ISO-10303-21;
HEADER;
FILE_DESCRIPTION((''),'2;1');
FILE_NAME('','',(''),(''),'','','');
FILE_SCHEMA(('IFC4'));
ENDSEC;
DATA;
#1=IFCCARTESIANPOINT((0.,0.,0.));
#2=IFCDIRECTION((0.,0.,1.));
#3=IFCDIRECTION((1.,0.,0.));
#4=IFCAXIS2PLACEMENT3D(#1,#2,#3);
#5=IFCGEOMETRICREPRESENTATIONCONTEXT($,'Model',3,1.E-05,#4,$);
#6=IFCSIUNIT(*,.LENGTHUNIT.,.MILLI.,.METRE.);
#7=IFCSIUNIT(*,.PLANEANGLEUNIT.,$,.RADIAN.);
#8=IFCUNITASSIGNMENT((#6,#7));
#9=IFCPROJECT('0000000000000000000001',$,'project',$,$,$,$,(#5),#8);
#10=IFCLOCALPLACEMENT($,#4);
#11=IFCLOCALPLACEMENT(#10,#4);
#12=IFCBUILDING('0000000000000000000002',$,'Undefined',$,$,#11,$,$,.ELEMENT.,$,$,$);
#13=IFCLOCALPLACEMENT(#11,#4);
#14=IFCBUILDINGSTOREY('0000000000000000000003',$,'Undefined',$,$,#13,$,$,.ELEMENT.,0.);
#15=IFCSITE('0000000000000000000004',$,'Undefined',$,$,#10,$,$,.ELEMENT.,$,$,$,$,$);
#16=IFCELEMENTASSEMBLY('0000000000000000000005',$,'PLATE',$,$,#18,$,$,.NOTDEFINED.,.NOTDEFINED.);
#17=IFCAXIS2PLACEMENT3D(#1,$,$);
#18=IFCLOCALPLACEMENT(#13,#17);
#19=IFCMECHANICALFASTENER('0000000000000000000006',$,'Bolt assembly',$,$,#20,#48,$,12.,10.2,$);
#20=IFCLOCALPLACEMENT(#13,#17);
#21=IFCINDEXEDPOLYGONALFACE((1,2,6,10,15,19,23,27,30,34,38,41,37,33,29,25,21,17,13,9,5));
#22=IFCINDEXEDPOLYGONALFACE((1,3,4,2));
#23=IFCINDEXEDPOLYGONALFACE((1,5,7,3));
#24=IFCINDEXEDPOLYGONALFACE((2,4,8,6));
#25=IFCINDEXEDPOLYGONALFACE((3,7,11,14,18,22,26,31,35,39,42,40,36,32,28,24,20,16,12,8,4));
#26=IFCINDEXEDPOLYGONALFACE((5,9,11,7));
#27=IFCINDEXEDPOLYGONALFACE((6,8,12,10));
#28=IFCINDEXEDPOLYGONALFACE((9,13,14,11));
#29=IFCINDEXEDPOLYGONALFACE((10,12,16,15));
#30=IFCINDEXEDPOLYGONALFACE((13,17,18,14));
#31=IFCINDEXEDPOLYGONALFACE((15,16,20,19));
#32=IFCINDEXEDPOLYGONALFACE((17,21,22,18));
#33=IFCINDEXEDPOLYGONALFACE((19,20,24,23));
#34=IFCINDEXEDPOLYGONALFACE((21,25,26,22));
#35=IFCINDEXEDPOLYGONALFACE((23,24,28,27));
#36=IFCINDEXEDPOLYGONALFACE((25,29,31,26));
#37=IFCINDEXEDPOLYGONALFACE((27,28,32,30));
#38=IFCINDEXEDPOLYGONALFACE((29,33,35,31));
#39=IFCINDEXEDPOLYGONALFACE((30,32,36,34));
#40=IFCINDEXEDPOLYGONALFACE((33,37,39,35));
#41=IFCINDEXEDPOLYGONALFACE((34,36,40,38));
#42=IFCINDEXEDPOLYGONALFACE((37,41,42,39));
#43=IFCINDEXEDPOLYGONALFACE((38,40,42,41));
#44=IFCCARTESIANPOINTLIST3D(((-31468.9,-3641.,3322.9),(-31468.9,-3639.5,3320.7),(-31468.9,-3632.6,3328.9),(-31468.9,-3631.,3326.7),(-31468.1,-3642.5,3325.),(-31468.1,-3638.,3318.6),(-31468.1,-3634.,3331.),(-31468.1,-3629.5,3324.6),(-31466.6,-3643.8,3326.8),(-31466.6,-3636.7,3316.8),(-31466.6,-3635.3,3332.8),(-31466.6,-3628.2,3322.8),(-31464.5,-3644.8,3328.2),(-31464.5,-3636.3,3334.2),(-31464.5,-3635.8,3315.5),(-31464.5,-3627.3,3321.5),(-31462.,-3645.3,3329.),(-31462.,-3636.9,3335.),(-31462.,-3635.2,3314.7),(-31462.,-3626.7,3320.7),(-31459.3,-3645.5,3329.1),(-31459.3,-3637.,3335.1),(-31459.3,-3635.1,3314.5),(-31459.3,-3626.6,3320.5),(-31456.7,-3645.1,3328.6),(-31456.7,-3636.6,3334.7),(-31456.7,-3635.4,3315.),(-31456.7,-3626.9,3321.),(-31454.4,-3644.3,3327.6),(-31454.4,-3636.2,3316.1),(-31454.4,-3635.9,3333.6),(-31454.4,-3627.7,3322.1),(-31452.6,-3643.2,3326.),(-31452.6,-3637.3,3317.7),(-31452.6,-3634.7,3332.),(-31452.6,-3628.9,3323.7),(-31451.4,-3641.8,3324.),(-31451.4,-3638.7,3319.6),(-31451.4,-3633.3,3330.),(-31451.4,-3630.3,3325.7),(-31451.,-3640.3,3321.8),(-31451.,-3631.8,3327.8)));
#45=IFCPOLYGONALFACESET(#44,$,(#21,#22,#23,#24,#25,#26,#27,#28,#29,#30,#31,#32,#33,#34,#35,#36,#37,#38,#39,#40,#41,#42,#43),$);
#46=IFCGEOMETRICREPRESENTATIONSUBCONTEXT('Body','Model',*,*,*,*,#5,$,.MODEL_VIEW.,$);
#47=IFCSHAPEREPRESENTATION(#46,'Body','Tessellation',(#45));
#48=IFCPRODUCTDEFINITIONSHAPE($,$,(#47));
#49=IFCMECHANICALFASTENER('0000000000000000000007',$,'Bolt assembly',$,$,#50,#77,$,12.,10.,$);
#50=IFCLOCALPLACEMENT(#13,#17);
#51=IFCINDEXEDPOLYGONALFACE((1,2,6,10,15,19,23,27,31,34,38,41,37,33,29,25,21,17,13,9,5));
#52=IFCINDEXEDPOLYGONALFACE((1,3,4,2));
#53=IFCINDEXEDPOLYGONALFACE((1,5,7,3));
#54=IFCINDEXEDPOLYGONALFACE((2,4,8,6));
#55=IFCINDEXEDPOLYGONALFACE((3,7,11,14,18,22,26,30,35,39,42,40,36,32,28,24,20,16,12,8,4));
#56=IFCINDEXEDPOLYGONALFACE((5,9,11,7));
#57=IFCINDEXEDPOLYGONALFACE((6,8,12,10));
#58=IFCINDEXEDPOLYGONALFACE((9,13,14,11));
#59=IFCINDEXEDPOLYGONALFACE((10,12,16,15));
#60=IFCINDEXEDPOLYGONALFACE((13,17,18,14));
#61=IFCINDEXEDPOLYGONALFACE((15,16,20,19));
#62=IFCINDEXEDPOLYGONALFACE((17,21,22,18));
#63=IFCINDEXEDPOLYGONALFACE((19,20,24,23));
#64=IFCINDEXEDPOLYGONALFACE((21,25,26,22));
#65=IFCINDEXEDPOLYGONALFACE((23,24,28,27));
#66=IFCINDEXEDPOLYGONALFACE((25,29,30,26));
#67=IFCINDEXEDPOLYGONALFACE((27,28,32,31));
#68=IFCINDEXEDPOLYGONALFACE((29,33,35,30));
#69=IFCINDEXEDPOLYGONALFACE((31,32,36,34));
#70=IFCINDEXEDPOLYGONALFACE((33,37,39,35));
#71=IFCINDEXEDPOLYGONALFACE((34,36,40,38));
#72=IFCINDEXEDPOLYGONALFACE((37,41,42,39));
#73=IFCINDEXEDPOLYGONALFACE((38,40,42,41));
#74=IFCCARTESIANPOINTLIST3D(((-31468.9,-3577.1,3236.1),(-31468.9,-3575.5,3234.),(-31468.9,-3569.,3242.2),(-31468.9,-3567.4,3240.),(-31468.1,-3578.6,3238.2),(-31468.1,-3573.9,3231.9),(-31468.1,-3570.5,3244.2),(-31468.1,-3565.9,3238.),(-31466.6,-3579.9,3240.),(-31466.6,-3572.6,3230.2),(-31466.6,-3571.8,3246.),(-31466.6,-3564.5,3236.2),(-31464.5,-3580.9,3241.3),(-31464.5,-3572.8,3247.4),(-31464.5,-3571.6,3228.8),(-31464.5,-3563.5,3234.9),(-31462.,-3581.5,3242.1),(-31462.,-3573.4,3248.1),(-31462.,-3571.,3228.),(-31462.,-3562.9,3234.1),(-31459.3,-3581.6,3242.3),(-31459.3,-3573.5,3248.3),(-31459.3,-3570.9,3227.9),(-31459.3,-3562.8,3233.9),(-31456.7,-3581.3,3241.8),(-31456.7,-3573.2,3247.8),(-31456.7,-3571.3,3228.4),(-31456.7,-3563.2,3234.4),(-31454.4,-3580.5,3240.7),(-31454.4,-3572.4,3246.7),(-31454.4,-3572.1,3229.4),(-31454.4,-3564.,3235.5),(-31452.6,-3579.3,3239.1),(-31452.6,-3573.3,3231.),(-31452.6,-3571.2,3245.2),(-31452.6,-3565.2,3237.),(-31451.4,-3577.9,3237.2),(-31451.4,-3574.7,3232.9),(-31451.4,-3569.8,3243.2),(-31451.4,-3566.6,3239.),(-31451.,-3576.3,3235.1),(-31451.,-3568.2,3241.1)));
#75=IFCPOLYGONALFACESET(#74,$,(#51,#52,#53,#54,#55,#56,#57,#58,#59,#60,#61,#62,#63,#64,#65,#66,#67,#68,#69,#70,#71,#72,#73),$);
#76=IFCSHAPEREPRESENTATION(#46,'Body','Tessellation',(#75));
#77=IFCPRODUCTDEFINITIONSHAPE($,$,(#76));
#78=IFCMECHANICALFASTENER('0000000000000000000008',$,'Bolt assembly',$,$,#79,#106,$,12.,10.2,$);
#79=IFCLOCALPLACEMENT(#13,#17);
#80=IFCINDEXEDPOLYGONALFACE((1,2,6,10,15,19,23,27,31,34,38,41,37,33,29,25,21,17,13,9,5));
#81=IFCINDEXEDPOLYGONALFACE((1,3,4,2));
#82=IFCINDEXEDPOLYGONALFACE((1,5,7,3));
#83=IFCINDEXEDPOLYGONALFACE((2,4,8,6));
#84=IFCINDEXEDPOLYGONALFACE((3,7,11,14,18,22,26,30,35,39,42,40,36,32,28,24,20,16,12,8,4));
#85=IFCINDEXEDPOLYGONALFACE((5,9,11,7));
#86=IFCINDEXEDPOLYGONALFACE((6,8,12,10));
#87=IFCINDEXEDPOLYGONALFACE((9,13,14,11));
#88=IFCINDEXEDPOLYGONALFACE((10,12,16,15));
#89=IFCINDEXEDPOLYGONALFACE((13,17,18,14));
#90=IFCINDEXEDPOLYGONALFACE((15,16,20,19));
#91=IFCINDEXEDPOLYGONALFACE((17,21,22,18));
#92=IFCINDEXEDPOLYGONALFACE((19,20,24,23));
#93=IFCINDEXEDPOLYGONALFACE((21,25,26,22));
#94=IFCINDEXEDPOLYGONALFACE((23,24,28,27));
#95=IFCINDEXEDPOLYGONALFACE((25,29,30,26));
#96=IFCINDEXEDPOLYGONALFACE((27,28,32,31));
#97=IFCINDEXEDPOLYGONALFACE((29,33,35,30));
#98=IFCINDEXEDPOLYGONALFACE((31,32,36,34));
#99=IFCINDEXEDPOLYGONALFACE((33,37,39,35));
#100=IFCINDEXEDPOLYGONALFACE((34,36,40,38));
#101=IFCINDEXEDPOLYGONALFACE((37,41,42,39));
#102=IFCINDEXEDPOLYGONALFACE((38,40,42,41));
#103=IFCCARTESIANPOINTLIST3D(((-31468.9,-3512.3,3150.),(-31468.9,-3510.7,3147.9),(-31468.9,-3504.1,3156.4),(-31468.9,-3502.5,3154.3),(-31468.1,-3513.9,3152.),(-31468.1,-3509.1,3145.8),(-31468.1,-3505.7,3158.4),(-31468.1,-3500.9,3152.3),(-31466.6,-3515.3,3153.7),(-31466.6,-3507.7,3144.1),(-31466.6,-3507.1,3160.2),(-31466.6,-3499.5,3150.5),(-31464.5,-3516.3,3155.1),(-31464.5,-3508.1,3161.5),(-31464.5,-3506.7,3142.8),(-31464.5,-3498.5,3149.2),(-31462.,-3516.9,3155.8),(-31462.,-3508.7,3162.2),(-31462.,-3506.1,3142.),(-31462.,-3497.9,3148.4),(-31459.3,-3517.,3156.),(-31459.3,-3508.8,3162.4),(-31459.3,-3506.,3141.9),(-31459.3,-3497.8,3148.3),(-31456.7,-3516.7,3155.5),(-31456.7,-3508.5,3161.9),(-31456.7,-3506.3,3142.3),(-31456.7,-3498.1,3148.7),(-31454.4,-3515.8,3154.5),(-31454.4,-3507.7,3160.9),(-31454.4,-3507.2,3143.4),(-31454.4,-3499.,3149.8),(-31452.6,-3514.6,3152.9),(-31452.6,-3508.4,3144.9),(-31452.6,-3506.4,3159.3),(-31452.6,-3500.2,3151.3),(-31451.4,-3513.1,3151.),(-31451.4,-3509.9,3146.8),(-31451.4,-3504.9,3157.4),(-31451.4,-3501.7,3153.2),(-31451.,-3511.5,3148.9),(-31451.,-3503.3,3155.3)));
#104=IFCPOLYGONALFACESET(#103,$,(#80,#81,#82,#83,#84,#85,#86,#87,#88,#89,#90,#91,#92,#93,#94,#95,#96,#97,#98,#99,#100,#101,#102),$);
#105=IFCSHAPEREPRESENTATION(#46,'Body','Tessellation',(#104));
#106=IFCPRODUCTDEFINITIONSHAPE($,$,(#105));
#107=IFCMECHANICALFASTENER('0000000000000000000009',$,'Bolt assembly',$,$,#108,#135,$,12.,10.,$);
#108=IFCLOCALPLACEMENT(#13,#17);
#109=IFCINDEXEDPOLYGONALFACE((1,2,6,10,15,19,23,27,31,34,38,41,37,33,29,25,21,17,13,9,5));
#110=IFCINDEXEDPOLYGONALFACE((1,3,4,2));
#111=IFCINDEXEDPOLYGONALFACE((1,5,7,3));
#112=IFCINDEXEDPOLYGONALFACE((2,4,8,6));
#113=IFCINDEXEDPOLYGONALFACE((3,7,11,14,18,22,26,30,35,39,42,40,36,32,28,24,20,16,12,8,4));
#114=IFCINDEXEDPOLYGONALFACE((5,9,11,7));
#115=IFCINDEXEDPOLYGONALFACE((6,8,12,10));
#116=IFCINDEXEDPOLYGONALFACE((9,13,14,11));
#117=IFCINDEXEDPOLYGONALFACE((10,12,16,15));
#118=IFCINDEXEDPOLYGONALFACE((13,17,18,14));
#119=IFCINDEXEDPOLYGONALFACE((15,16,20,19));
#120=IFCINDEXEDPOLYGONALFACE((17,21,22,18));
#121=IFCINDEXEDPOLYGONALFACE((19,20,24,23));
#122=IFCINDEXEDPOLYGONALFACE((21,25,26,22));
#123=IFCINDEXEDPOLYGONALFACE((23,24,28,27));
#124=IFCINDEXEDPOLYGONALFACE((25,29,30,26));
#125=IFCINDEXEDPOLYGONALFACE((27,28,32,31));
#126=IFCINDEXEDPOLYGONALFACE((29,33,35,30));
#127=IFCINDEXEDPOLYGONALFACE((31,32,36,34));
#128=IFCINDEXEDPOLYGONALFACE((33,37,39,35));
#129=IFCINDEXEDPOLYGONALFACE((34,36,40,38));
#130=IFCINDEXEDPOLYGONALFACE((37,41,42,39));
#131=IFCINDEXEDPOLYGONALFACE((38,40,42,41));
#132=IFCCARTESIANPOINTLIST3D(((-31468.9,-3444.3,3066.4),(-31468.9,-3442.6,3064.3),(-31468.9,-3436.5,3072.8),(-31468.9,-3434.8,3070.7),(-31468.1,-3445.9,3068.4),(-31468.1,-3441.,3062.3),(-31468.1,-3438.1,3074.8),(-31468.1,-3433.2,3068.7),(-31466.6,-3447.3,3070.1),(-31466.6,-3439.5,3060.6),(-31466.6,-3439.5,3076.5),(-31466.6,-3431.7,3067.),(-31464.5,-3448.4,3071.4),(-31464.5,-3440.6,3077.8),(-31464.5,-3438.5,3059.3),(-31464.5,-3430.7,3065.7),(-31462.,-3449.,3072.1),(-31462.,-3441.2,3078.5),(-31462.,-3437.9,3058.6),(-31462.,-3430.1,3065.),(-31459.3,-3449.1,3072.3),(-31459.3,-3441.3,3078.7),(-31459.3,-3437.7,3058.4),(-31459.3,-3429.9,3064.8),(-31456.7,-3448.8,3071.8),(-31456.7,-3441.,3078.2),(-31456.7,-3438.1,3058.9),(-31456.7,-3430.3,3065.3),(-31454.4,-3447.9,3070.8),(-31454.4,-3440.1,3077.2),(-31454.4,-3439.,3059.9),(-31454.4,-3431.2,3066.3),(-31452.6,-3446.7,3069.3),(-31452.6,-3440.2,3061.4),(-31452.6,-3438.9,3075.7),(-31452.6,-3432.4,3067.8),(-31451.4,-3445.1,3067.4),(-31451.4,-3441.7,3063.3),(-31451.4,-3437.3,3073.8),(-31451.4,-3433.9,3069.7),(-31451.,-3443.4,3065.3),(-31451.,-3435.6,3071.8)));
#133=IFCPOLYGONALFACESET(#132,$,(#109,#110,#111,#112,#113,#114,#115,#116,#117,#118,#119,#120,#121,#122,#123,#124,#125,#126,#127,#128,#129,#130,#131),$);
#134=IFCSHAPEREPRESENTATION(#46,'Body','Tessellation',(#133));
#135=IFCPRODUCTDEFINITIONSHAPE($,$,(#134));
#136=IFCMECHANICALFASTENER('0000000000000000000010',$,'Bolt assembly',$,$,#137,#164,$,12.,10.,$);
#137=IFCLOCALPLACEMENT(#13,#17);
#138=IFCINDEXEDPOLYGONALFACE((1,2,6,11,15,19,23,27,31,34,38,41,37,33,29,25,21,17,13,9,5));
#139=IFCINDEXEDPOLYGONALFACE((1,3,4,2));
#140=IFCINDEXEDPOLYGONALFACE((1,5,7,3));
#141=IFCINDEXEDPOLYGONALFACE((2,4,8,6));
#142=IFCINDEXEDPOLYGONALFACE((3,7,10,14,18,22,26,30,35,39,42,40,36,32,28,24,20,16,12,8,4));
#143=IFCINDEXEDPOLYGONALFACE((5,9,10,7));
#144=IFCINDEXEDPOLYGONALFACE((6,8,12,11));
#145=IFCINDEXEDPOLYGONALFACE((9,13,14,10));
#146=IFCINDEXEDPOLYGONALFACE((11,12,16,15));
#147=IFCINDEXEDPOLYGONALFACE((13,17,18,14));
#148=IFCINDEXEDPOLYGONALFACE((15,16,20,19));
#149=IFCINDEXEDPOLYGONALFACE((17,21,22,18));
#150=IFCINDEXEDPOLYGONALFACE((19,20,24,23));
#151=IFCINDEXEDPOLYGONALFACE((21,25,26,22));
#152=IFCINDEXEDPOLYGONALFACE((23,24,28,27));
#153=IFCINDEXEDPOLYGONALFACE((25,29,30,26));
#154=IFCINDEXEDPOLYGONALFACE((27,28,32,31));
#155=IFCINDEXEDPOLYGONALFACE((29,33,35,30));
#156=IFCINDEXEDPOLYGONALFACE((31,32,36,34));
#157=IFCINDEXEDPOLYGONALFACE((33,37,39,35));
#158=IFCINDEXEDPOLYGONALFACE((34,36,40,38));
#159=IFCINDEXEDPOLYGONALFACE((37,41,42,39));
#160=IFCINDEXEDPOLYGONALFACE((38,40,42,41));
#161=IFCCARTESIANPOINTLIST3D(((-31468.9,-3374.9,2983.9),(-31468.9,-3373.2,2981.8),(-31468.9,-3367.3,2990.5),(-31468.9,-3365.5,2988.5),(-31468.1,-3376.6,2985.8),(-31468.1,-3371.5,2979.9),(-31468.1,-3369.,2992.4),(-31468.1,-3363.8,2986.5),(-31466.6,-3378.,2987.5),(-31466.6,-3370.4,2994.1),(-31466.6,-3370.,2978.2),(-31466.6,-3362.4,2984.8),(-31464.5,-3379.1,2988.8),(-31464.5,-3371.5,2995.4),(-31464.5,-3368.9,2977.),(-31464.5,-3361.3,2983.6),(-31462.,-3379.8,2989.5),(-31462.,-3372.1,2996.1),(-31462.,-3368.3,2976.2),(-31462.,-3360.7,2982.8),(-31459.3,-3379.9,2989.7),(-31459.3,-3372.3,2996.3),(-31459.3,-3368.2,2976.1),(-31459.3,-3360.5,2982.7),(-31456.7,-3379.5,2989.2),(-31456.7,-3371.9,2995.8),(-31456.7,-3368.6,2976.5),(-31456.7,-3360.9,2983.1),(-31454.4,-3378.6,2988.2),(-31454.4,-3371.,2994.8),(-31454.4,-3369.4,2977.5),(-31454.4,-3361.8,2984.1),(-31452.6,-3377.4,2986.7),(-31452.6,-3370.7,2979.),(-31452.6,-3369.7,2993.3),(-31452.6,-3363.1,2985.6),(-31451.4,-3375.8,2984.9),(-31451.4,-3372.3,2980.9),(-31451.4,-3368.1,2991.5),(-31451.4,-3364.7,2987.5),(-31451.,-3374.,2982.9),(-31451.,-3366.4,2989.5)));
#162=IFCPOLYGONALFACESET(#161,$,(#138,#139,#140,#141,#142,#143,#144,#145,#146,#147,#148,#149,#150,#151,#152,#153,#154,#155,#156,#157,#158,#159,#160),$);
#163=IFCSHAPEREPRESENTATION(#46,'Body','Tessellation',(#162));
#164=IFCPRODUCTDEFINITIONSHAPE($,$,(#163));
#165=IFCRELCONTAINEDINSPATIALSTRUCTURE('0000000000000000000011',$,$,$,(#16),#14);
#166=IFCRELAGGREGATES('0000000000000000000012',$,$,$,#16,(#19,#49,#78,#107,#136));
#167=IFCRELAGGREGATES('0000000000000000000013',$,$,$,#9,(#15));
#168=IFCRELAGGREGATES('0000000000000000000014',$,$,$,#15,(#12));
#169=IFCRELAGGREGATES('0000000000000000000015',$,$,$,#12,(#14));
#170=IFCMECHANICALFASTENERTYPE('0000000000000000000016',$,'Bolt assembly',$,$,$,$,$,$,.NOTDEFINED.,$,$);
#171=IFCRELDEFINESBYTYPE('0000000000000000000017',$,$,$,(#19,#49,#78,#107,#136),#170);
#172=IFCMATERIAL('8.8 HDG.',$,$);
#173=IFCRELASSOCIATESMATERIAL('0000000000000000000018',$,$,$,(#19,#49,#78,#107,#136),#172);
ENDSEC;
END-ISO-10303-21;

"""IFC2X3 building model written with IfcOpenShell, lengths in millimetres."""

from ifc_helpers import new_model, si_unit, frame, origin_with_axes, origin_2d_with_axis, place, context, subcontext, project, spatial, circle, extrude, source, transform, mapped, material, type_object, element, aggregate, save


model = new_model("IFC2X3")

# Units and contexts
model_context = context("Model", 3, precision=1e-05, world=origin_with_axes())
body_context = subcontext(model_context, "Body", "Model", "MODEL_VIEW")
ifc_project = project(units=[si_unit("LENGTHUNIT", "METRE", prefix="MILLI"), si_unit("PLANEANGLEUNIT", "RADIAN")], contexts=[model_context])

# Site, building, storey
site_placement = place(None, origin_with_axes())
site = spatial("IfcSite", under=ifc_project, at=site_placement, Name="Undefined", CompositionType="ELEMENT")
building_placement = place(site_placement, origin_with_axes())
building = spatial("IfcBuilding", under=site, at=building_placement, Name="Undefined", CompositionType="ELEMENT")
storey_placement = place(building_placement, origin_with_axes())
storey = spatial("IfcBuildingStorey", under=building, at=storey_placement, Name="Undefined", CompositionType="ELEMENT", Elevation=0.0)

# Element assembly
assembly_1_placement = place(storey_placement, origin_with_axes())
assembly_1 = element("IfcElementAssembly", 1, at=assembly_1_placement, inside=storey, Name="PLATE", AssemblyPlace="NOTDEFINED", PredefinedType="NOTDEFINED")

# Shared definitions
mechanical_fastener_type = type_object("IfcMechanicalFastenerType", Name="Bolt assembly")

# Mechanical fasteners
ifc_material_1 = material(Name="8.8 HDG.")
shared_shape_1 = source(origin_with_axes(), body_context, "Body", "SweptSolid", [
    extrude(circle(Radius=9.0, at=origin_2d_with_axis()), frame((0.0, 0.2, 0.0), z_axis=(0.0, 1.0, 0.0), x_axis=(1.0, 0.0, 0.0)), (0.0, 0.0, 1.0), 10.4),
])
mechanical_fastener_1_placement = place(assembly_1_placement, frame((-31460.0, -3640.4, 3321.7), z_axis=(0.000001, -0.577967, 0.81606), x_axis=(1.0, 0.000001, -0.000001)))
mechanical_fastener_1 = element("IfcMechanicalFastener", 2, at=mechanical_fastener_1_placement, type_object=mechanical_fastener_type, material=ifc_material_1, Name="Bolt assembly", NominalDiameter=12.0, NominalLength=10.2, context=body_context, shape_type="MappedRepresentation", body=[
    mapped(shared_shape_1, transform((0.0, 0.0, 0.0))),
])
shared_shape_2 = source(origin_with_axes(), body_context, "Body", "SweptSolid", [
    extrude(circle(Radius=9.0, at=origin_2d_with_axis()), frame((0.0, 0.9, 0.0), z_axis=(0.0, 1.0, 0.0), x_axis=(1.0, 0.0, 0.0)), (0.0, 0.0, 1.0), 10.1),
])
mechanical_fastener_2_placement = place(assembly_1_placement, frame((-31460.0, -3577.0, 3234.5), z_axis=(0.000001, -0.597518, 0.801856), x_axis=(1.0, 0.000001, -0.000001)))
mechanical_fastener_2 = element("IfcMechanicalFastener", 3, at=mechanical_fastener_2_placement, type_object=mechanical_fastener_type, material=ifc_material_1, Name="Bolt assembly", NominalDiameter=12.0, NominalLength=10.0, context=body_context, shape_type="MappedRepresentation", body=[
    mapped(shared_shape_2, transform((0.0, 0.0, 0.0))),
])
shared_shape_3 = source(origin_with_axes(), body_context, "Body", "SweptSolid", [
    extrude(circle(Radius=9.0, at=origin_2d_with_axis()), frame((0.0, 0.1, 0.0), z_axis=(0.0, 1.0, 0.0), x_axis=(1.0, 0.0, 0.0)), (0.0, 0.0, 1.0), 10.4),
])
mechanical_fastener_3_placement = place(assembly_1_placement, frame((-31460.0, -3511.6, 3148.9), z_axis=(0.000001, -0.616719, 0.787183), x_axis=(1.0, 0.000001, -0.000001)))
mechanical_fastener_3 = element("IfcMechanicalFastener", 4, at=mechanical_fastener_3_placement, type_object=mechanical_fastener_type, material=ifc_material_1, Name="Bolt assembly", NominalDiameter=12.0, NominalLength=10.2, context=body_context, shape_type="MappedRepresentation", body=[
    mapped(shared_shape_3, transform((0.0, 0.0, 0.0))),
])
shared_shape_4 = source(origin_with_axes(), body_context, "Body", "SweptSolid", [
    extrude(circle(Radius=9.0, at=origin_2d_with_axis()), frame((0.0, 0.8, 0.0), z_axis=(0.0, 1.0, 0.0), x_axis=(1.0, 0.0, 0.0)), (0.0, 0.0, 1.0), 10.1),
])
mechanical_fastener_4_placement = place(assembly_1_placement, frame((-31460.0, -3444.1, 3064.8), z_axis=(0.000001, -0.63556, 0.772051), x_axis=(1.0, 0.000001, -0.000001)))
mechanical_fastener_4 = element("IfcMechanicalFastener", 5, at=mechanical_fastener_4_placement, type_object=mechanical_fastener_type, material=ifc_material_1, Name="Bolt assembly", NominalDiameter=12.0, NominalLength=10.0, context=body_context, shape_type="MappedRepresentation", body=[
    mapped(shared_shape_4, transform((0.0, 0.0, 0.0))),
])
shared_shape_5 = source(origin_with_axes(), body_context, "Body", "SweptSolid", [
    extrude(circle(Radius=9.0, at=origin_2d_with_axis()), frame((0.0, 0.7, 0.0), z_axis=(0.0, 1.0, 0.0), x_axis=(1.0, 0.0, 0.0)), (0.0, 0.0, 1.0), 10.1),
])
mechanical_fastener_5_placement = place(assembly_1_placement, frame((-31460.0, -3374.6, 2982.4), z_axis=(0.000001, -0.65403, 0.756468), x_axis=(1.0, 0.000001, -0.000001)))
mechanical_fastener_5 = element("IfcMechanicalFastener", 6, at=mechanical_fastener_5_placement, type_object=mechanical_fastener_type, material=ifc_material_1, Name="Bolt assembly", NominalDiameter=12.0, NominalLength=10.0, context=body_context, shape_type="MappedRepresentation", body=[
    mapped(shared_shape_5, transform((0.0, 0.0, 0.0))),
])
aggregate(assembly_1, [mechanical_fastener_1, mechanical_fastener_2, mechanical_fastener_3, mechanical_fastener_4, mechanical_fastener_5])

save(model, "model.ifc")
